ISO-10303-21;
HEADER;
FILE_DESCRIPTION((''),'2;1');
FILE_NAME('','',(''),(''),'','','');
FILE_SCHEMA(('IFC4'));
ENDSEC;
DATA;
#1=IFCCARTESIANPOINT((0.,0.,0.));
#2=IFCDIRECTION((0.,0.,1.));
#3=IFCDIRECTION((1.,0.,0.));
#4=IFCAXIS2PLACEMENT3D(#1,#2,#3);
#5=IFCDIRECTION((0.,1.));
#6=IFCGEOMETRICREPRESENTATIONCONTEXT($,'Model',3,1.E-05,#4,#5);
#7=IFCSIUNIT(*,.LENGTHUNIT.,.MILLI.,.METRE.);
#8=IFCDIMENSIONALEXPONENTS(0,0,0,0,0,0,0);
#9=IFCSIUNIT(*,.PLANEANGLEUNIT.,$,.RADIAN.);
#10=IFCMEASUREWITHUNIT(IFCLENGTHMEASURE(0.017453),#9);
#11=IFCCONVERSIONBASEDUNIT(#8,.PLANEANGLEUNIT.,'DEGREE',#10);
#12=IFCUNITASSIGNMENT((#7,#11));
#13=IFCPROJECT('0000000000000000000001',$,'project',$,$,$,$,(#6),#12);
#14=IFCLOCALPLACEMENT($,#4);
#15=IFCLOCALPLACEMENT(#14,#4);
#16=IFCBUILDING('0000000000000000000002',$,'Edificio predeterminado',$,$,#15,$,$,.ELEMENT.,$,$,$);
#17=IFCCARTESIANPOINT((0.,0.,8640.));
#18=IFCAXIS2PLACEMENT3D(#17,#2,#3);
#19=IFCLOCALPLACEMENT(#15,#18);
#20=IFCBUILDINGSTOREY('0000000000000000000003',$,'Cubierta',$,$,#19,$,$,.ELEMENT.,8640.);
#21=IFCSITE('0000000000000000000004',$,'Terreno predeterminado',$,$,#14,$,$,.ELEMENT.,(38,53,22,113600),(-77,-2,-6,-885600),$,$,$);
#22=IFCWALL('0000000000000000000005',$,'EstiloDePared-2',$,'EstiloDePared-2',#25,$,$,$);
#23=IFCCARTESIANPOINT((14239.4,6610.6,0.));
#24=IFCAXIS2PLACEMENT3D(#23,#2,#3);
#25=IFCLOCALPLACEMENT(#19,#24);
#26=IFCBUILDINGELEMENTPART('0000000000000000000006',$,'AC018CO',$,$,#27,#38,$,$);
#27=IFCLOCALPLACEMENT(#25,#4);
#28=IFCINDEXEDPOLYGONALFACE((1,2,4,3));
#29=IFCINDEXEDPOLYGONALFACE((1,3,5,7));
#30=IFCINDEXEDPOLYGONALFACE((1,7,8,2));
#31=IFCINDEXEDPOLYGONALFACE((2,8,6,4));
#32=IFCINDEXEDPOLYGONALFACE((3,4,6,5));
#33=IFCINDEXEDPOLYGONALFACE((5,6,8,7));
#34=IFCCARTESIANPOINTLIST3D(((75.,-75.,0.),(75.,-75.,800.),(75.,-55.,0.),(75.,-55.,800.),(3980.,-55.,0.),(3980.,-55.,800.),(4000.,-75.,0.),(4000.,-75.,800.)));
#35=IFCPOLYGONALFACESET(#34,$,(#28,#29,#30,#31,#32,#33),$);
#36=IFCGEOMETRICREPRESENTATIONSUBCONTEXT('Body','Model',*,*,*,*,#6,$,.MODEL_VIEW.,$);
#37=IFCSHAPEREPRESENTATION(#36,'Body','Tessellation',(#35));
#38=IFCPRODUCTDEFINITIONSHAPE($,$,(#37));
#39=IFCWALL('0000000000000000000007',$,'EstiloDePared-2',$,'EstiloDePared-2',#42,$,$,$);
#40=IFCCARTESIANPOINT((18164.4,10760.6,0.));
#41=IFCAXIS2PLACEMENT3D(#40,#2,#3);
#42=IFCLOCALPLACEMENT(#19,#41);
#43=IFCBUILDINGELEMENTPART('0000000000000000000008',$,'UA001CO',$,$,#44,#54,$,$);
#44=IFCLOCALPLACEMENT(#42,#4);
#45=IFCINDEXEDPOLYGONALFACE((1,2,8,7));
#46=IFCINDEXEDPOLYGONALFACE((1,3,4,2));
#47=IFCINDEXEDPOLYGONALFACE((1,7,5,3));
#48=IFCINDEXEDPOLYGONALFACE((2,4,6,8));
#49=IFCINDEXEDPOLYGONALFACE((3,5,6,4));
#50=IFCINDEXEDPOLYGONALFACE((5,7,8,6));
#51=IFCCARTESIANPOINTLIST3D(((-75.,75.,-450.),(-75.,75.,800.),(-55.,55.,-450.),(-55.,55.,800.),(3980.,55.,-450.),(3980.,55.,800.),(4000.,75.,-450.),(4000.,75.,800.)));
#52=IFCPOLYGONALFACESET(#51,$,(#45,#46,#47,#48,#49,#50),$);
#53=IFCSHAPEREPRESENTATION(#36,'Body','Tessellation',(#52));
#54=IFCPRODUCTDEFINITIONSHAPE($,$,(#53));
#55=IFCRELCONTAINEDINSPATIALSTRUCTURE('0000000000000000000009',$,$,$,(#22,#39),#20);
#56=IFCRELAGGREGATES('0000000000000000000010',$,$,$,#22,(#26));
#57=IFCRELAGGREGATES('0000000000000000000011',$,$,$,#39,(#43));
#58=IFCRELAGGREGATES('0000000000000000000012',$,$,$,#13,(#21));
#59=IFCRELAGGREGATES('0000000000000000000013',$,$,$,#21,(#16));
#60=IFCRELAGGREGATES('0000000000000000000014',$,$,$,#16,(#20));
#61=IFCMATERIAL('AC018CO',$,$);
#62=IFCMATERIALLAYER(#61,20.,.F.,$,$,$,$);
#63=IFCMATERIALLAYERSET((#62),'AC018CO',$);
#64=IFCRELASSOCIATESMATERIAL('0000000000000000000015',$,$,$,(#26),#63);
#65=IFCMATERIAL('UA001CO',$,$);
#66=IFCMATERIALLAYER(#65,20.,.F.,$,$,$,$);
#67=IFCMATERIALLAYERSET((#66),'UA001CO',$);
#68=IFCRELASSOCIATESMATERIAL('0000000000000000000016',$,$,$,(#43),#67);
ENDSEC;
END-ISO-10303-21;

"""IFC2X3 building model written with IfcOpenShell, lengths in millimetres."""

from ifc_helpers import new_model, entity, si_unit, converted_unit, direction, frame, origin_with_axes, place, context, subcontext, project, spatial, polyline, outline, extrude, material, layer, layer_set, layer_usage, element, aggregate, save


model = new_model("IFC2X3")

# Units and contexts
model_context = context("Model", 3, precision=1e-05, world=origin_with_axes(), true_north=direction((0.0, 1.0)))
body_context = subcontext(model_context, "Body", "Model", "MODEL_VIEW")
ifc_project = project(units=[si_unit("LENGTHUNIT", "METRE", prefix="MILLI"), converted_unit("PLANEANGLEUNIT", "DEGREE", entity("IfcLengthMeasure", 0.017453), si_unit("PLANEANGLEUNIT", "RADIAN"), dimensions=[0, 0, 0, 0, 0, 0, 0])], contexts=[model_context])

# Site, building, storey
site_placement = place(None, origin_with_axes())
site = spatial("IfcSite", under=ifc_project, at=site_placement, Name="Terreno predeterminado", CompositionType="ELEMENT", RefLatitude=(38, 53, 22, 113600), RefLongitude=(-77, -2, -6, -885600))
building_placement = place(site_placement, origin_with_axes())
building = spatial("IfcBuilding", under=site, at=building_placement, Name="Edificio predeterminado", CompositionType="ELEMENT")
storey_placement = place(building_placement, frame((0.0, 0.0, 8640.0), z_axis=(0.0, 0.0, 1.0), x_axis=(1.0, 0.0, 0.0)))
storey = spatial("IfcBuildingStorey", under=building, at=storey_placement, Name="Cubierta", CompositionType="ELEMENT", Elevation=8640.0)

# Walls, building element parts
wall_1_placement = place(storey_placement, frame((14239.4, 6610.6, 0.0), z_axis=(0.0, 0.0, 1.0), x_axis=(1.0, 0.0, 0.0)))
wall_1 = element("IfcWall", 1, at=wall_1_placement, inside=storey, Name="EstiloDePared-2", ObjectType="EstiloDePared-2")
ifc_material_1 = material(Name="AC018CO")
ifc_layer_1 = layer(ifc_material_1, 20.0, ventilated=False)
ifc_layer_set_1 = layer_set([ifc_layer_1], Name="AC018CO")
ifc_layer_usage_1 = layer_usage(ifc_layer_set_1, "AXIS2", "NEGATIVE", 55.0)
building_element_part_1_placement = place(wall_1_placement, origin_with_axes())
building_element_part_1 = element("IfcBuildingElementPart", 2, at=building_element_part_1_placement, material=ifc_layer_usage_1, Name="AC018CO", context=body_context, shape_type="SweptSolid", body=[
    extrude(outline(polyline([(3980.0, -55.0), (4000.0, -75.0), (75.0, -75.0), (75.0, -55.0), (3980.0, -55.0)])), origin_with_axes(), (0.0, 0.0, 1.0), 800.0),
])
aggregate(wall_1, [building_element_part_1])
wall_2_placement = place(storey_placement, frame((18164.4, 10760.6, 0.0), z_axis=(0.0, 0.0, 1.0), x_axis=(1.0, 0.0, 0.0)))
wall_2 = element("IfcWall", 3, at=wall_2_placement, inside=storey, Name="EstiloDePared-2", ObjectType="EstiloDePared-2")
ifc_material_2 = material(Name="UA001CO")
ifc_layer_2 = layer(ifc_material_2, 20.0, ventilated=False)
ifc_layer_set_2 = layer_set([ifc_layer_2], Name="UA001CO")
ifc_layer_usage_2 = layer_usage(ifc_layer_set_2, "AXIS2", "NEGATIVE", -75.0)
building_element_part_2_placement = place(wall_2_placement, origin_with_axes())
building_element_part_2 = element("IfcBuildingElementPart", 4, at=building_element_part_2_placement, material=ifc_layer_usage_2, Name="UA001CO", context=body_context, shape_type="SweptSolid", body=[
    extrude(outline(polyline([(4000.0, 75.0), (3980.0, 55.0), (-55.0, 55.0), (-75.0, 75.0), (4000.0, 75.0)])), frame((0.0, 0.0, -450.0), z_axis=(0.0, 0.0, 1.0), x_axis=(1.0, 0.0, 0.0)), (0.0, 0.0, 1.0), 1250.0),
])
aggregate(wall_2, [building_element_part_2])

save(model, "model.ifc")
